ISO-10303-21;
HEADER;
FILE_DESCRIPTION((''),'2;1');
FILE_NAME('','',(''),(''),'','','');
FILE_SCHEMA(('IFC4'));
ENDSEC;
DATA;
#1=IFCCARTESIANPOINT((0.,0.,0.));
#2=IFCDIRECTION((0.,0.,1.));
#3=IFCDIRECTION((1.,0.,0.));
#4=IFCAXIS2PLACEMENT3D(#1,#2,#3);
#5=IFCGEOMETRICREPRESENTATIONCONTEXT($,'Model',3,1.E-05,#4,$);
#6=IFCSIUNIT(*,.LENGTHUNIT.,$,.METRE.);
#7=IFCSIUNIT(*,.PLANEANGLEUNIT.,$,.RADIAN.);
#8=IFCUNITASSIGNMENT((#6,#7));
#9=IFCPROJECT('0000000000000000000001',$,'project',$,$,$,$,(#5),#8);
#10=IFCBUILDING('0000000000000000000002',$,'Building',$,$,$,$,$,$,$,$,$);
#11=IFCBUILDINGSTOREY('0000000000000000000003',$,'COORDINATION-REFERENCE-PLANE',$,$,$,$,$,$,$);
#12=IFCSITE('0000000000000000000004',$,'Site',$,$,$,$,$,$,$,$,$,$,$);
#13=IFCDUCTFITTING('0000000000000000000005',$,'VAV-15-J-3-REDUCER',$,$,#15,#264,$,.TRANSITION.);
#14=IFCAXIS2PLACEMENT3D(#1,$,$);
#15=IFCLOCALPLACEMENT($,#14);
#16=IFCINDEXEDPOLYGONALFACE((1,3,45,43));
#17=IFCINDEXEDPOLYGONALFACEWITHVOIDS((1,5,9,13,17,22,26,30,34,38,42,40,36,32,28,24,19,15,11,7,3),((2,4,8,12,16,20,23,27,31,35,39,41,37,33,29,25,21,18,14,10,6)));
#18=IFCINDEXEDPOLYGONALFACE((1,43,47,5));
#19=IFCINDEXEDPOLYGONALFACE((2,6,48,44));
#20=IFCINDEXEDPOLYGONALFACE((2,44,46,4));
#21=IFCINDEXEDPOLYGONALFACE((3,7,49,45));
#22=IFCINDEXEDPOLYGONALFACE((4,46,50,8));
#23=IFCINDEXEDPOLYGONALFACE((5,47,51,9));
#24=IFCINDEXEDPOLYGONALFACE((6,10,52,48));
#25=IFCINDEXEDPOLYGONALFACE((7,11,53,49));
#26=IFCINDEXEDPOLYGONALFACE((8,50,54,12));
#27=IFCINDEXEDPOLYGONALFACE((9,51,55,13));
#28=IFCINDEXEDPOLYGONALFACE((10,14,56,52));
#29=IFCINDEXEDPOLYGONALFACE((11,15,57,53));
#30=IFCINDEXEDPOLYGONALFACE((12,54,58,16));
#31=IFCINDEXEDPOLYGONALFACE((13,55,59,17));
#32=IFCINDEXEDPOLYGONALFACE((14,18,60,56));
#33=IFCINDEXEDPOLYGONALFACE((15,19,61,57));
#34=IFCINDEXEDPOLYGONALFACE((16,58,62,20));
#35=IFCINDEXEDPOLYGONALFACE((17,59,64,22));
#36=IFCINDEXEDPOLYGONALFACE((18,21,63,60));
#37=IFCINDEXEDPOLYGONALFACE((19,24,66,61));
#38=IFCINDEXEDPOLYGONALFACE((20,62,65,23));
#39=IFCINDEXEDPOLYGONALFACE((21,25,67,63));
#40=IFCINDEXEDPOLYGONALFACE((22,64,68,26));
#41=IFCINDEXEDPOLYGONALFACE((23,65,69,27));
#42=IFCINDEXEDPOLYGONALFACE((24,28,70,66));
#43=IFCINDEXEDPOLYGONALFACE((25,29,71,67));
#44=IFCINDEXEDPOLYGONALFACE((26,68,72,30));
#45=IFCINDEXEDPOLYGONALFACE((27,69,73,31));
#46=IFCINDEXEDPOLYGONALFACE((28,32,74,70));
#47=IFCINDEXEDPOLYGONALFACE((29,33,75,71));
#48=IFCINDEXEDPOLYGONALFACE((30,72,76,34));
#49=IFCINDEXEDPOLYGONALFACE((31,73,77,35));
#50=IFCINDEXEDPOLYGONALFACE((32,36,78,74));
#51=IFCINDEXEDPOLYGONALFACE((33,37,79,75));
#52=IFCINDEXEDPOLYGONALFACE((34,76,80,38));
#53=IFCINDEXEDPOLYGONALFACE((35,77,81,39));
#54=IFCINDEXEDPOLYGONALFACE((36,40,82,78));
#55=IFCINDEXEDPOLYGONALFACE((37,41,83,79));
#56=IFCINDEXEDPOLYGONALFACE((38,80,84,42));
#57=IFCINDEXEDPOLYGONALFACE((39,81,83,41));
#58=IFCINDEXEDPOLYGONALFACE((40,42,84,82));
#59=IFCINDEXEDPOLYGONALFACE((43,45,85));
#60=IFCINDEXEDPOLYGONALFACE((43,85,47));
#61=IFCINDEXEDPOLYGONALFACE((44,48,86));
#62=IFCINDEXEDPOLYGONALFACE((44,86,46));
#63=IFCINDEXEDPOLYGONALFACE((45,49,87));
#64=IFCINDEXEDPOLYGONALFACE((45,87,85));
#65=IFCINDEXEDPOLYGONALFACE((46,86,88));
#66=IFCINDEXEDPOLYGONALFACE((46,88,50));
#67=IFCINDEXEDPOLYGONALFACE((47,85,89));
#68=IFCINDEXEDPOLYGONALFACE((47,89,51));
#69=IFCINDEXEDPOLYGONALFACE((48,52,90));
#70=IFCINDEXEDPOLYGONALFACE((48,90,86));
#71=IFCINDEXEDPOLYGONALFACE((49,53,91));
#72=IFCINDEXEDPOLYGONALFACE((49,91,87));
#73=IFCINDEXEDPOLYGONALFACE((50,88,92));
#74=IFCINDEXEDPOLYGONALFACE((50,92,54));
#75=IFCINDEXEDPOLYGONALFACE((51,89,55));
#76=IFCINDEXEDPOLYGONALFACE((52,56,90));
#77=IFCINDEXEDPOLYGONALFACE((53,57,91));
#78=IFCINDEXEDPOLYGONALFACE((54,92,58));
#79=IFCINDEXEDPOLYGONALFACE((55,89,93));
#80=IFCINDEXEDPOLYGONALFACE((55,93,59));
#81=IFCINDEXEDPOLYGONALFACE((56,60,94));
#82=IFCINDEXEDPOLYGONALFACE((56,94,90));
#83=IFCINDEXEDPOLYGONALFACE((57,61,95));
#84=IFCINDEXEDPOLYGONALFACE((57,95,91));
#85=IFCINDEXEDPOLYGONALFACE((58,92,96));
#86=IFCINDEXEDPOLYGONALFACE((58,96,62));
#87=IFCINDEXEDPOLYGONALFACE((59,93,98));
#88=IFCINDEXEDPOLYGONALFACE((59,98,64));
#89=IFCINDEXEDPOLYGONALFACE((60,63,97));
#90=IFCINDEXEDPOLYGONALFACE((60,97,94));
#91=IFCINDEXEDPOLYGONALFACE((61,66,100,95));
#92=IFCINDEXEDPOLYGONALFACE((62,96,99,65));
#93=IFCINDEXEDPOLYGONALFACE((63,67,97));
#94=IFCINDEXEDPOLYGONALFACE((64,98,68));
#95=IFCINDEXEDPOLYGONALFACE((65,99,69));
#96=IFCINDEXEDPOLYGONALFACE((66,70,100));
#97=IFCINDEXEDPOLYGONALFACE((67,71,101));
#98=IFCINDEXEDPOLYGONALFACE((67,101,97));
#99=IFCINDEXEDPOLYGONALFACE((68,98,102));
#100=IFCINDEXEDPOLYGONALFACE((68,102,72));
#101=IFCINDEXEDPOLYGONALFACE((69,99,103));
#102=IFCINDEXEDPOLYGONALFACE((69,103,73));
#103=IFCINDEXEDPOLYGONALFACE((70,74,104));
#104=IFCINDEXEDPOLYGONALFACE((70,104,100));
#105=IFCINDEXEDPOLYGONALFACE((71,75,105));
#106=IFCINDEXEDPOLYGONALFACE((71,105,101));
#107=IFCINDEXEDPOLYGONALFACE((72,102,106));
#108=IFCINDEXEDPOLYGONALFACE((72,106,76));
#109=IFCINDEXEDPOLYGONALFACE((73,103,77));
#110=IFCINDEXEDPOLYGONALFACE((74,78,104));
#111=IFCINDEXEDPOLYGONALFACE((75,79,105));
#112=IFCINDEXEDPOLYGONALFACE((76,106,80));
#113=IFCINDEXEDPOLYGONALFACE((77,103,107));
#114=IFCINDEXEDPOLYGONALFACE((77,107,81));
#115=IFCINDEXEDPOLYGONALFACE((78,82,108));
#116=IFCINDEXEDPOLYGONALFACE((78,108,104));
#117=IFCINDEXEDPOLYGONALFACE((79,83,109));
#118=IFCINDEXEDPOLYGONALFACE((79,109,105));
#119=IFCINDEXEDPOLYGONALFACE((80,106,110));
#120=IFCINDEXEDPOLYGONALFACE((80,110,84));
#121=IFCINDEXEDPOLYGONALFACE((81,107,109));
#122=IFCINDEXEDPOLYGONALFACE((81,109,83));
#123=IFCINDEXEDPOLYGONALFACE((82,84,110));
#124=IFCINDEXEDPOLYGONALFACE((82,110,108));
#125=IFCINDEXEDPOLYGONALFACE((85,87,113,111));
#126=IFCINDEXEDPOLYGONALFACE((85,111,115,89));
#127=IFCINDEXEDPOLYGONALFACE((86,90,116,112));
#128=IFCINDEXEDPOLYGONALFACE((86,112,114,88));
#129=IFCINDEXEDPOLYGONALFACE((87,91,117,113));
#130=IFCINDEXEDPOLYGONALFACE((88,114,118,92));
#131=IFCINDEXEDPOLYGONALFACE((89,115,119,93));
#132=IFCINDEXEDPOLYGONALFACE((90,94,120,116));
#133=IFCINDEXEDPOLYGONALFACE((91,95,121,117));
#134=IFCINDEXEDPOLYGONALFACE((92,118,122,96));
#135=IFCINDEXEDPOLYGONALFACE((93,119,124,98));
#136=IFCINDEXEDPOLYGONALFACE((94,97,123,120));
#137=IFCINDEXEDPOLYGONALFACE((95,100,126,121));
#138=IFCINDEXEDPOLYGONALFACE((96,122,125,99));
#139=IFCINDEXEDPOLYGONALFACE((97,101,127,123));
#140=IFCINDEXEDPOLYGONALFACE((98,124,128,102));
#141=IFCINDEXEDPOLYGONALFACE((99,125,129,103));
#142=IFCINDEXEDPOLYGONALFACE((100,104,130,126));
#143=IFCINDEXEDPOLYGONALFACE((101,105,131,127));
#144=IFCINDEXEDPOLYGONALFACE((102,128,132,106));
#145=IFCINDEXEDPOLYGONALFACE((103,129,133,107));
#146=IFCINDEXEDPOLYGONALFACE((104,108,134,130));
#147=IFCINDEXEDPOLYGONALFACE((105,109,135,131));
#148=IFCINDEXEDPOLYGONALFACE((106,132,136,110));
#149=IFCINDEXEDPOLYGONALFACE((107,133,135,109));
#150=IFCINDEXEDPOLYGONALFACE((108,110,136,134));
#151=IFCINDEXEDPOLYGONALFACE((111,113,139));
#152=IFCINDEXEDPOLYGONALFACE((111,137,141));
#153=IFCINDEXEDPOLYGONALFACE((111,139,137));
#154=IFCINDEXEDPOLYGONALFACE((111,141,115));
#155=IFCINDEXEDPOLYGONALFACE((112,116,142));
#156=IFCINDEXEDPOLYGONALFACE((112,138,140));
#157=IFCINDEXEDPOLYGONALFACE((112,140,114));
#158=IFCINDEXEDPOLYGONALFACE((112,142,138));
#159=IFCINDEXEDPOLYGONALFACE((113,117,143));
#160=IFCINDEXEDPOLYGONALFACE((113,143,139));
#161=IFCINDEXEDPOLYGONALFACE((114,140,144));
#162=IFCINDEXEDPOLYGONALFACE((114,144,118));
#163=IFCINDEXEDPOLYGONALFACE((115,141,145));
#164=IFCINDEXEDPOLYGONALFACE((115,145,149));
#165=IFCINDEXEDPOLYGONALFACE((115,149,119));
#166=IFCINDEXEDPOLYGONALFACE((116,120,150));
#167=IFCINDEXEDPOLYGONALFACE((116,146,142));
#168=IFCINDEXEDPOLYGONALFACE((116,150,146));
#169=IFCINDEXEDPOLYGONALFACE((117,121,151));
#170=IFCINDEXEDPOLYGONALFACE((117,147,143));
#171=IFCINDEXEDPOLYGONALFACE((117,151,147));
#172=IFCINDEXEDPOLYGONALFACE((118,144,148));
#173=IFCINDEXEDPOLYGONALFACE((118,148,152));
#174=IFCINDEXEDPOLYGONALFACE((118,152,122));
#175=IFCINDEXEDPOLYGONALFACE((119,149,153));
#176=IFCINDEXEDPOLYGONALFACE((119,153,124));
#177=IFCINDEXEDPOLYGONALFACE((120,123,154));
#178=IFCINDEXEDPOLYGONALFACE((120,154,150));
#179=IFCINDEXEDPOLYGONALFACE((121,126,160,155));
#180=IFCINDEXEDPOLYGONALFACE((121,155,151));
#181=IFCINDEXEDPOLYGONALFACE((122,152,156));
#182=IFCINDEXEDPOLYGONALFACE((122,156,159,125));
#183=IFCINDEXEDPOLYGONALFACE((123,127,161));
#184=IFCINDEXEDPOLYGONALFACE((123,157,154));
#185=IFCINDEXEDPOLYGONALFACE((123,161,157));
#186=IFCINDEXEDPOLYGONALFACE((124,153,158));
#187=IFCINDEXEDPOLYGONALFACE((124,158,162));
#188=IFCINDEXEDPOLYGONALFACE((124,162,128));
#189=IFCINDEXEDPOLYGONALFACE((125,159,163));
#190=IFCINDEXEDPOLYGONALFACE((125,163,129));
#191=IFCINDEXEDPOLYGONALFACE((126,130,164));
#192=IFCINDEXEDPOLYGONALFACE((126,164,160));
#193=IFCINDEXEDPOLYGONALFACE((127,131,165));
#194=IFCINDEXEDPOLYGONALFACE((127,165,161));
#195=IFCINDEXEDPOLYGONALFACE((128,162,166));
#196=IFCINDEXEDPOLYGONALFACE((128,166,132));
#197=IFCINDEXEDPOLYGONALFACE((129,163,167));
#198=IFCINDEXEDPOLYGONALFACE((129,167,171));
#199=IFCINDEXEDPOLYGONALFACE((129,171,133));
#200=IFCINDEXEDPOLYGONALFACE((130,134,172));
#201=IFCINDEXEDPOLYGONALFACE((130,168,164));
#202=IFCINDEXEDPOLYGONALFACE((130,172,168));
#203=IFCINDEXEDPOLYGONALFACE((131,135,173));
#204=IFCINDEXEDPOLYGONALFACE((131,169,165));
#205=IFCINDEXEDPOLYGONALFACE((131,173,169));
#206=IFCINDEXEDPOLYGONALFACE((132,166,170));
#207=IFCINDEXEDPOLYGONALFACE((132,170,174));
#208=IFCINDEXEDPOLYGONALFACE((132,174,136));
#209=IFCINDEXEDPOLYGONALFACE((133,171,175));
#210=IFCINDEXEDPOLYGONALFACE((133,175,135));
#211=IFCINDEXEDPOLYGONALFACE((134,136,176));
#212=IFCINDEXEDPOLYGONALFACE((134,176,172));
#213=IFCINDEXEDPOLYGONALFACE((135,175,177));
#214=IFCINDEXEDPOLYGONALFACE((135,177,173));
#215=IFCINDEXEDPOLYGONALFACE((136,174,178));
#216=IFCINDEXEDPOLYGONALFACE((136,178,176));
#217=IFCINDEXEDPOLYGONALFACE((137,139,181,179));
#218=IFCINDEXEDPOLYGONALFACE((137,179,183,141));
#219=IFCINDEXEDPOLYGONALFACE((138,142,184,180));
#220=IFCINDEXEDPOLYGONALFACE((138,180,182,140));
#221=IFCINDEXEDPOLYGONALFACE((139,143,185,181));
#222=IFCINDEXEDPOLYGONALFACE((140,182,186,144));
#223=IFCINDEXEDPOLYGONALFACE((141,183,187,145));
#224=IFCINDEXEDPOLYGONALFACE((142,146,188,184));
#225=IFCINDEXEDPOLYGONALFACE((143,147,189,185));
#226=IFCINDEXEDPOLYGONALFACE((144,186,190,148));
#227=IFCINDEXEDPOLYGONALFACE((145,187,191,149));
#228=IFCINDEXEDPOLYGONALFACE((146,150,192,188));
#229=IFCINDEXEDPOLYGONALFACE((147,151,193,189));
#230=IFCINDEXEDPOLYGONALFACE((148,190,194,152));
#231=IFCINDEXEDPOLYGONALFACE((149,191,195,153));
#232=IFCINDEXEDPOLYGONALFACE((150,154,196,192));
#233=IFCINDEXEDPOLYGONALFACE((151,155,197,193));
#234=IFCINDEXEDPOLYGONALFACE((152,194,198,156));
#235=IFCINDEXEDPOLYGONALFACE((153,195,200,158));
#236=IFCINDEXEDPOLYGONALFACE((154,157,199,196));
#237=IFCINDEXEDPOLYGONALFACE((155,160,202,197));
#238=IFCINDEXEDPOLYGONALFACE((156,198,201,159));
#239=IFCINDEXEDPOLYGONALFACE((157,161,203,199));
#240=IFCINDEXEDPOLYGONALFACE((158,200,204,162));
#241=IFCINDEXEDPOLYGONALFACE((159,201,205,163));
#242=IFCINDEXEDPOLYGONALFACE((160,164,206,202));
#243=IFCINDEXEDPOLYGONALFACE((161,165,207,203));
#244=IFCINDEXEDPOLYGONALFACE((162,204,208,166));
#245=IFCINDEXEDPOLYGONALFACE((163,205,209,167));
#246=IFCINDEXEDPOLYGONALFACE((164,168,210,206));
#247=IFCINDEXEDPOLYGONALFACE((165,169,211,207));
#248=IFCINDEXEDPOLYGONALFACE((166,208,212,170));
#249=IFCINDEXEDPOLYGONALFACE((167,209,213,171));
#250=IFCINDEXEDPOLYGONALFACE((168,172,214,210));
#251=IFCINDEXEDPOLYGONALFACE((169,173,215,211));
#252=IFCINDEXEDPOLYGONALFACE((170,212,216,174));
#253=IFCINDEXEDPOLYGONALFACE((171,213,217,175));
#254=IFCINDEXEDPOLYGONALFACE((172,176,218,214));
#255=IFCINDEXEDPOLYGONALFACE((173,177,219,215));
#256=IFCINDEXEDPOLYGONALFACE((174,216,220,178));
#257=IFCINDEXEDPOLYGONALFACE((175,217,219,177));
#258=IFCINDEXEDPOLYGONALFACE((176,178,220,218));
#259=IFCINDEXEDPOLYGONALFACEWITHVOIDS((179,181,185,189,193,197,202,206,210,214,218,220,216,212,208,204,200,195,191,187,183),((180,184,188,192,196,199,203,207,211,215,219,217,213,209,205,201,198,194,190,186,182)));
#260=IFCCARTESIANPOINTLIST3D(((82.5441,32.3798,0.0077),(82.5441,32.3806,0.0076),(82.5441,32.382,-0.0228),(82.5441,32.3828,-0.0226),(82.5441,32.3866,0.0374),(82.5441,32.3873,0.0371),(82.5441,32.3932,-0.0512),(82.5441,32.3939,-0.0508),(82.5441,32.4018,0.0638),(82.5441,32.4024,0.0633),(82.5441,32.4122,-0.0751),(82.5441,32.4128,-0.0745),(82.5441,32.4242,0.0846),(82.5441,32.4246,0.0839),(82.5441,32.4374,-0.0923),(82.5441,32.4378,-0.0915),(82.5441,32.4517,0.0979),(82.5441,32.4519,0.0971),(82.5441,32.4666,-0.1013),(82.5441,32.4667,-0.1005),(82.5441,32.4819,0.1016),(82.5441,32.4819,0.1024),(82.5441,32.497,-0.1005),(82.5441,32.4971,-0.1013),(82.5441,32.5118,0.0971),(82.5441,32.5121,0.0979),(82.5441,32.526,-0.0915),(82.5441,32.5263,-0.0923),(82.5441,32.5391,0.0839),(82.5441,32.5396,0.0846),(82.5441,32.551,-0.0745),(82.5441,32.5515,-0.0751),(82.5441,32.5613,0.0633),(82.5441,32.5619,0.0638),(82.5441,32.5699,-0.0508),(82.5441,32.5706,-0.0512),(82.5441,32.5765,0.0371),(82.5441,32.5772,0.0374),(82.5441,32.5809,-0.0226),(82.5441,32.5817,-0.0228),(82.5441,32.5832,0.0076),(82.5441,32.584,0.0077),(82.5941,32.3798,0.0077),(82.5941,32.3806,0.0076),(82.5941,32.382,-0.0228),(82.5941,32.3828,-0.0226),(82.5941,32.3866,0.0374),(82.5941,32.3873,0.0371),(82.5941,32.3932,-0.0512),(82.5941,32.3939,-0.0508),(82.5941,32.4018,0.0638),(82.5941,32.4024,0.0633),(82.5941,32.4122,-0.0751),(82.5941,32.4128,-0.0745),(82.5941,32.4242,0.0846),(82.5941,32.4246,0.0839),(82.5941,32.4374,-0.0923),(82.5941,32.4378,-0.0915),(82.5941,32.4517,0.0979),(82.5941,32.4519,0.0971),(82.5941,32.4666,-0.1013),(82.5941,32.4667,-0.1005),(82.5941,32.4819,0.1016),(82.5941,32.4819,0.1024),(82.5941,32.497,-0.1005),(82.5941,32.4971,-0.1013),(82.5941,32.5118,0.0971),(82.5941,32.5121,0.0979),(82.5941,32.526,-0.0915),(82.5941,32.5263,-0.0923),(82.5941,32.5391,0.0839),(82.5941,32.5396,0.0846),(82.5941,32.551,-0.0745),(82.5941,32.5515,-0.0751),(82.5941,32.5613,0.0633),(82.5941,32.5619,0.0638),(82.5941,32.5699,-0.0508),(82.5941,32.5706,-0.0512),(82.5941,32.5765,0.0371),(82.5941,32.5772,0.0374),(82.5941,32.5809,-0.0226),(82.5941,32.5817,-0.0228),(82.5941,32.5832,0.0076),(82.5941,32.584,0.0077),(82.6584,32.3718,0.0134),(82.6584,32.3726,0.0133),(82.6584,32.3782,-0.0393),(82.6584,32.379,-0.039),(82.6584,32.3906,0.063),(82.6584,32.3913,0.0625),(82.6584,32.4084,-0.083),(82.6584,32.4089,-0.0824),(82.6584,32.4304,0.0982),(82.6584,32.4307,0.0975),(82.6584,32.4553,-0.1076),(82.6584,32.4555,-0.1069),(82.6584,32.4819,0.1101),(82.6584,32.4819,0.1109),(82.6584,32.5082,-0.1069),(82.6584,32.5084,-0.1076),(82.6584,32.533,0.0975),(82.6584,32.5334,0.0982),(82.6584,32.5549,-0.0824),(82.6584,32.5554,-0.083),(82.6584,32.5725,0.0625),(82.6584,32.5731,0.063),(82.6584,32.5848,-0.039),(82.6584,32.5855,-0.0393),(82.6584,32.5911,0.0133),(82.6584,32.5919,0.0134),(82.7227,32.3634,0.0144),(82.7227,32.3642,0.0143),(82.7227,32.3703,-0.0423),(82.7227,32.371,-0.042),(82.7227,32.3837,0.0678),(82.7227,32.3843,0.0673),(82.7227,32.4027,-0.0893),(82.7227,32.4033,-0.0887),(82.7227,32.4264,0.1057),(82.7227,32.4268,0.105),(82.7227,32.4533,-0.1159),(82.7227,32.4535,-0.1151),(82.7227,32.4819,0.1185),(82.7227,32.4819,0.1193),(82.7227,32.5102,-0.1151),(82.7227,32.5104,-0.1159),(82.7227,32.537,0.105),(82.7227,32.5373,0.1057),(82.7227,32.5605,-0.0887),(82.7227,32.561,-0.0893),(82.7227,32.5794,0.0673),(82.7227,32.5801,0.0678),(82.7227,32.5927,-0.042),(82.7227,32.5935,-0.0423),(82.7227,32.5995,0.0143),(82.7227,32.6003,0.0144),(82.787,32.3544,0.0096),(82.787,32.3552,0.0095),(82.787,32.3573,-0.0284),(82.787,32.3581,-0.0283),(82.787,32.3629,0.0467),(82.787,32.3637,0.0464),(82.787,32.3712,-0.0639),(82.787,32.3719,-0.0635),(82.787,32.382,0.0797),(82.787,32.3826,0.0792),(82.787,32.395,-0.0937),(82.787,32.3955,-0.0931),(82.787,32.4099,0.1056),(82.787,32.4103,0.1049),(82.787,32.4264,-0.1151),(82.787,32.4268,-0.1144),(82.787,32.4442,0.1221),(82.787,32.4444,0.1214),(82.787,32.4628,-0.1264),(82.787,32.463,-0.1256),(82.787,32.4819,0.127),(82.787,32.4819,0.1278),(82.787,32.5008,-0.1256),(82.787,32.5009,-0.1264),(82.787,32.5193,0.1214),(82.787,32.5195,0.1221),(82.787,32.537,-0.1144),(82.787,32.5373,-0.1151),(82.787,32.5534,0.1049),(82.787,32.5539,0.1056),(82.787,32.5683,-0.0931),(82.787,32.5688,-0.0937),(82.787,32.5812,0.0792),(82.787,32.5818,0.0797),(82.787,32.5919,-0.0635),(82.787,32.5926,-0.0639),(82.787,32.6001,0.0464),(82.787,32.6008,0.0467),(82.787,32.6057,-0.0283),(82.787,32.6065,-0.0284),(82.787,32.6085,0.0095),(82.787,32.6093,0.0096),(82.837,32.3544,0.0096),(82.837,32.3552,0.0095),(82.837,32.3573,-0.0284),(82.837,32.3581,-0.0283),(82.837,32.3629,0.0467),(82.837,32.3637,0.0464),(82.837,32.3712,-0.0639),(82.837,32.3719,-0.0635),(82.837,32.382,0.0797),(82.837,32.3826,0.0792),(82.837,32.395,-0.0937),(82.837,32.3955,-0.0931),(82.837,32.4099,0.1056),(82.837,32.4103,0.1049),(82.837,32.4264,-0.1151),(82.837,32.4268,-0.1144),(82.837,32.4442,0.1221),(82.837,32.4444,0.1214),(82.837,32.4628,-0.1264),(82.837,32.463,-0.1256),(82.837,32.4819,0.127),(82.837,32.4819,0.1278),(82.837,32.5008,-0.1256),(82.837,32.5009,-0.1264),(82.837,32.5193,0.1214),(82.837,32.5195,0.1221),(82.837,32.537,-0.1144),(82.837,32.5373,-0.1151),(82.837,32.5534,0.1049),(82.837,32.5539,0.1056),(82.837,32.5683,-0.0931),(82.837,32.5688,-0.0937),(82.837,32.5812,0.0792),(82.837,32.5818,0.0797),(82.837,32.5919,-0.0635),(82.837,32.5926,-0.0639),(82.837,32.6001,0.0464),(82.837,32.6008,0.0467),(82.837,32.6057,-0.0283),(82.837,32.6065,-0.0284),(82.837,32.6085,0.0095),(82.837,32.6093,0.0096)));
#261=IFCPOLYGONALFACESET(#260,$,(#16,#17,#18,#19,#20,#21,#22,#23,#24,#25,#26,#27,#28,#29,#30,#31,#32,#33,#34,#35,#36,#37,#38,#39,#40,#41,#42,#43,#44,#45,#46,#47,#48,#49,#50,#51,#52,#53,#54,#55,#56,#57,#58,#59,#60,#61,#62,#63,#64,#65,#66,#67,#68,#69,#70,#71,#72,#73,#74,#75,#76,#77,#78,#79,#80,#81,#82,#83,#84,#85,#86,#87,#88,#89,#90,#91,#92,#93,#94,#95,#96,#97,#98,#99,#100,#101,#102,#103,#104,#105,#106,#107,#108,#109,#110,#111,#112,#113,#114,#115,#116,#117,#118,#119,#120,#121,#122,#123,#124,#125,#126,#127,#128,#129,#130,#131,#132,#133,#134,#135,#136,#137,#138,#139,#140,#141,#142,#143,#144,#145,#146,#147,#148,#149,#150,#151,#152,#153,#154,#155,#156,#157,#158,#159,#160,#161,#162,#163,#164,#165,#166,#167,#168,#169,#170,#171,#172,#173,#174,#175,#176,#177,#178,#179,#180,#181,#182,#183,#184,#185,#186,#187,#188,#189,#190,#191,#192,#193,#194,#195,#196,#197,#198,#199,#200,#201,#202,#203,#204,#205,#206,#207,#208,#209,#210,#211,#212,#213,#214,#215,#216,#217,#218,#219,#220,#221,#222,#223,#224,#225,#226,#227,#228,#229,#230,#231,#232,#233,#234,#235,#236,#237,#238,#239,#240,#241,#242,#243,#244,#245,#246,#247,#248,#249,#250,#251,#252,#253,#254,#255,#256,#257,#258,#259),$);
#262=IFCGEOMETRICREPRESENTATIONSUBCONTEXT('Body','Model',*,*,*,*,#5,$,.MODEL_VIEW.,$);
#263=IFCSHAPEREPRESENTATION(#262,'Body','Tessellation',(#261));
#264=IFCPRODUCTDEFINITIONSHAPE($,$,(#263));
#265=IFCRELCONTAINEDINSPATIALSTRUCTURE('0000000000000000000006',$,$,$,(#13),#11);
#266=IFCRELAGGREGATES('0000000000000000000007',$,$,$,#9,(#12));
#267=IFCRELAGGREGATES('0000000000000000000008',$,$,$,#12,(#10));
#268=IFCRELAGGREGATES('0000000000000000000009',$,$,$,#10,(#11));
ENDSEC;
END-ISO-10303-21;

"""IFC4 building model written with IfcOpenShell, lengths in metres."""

from ifc_helpers import new_model, entity, si_unit, frame, origin_with_axes, place, context, subcontext, project, spatial, element, save


model = new_model("IFC4")

# Units and contexts
model_context = context("Model", 3, precision=1e-05, world=origin_with_axes())
body_context_1 = subcontext(model_context, "Body", "Model", "MODEL_VIEW")
ifc_project = project(units=[si_unit("LENGTHUNIT", "METRE"), si_unit("PLANEANGLEUNIT", "RADIAN")], contexts=[model_context])

# Site, building, storey
site = spatial("IfcSite", under=ifc_project, Name="Site")
building = spatial("IfcBuilding", under=site, Name="Building")
storey = spatial("IfcBuildingStorey", under=building, Name="COORDINATION-REFERENCE-PLANE")

# Duct fitting
for number, where, z_axis, x_axis, name in (
    (1, (82.837, 32.4819, 0.0), (0.0, -1.0, 0.0), (0.0, 0.0, 1.0), "VAV-15-J-3-REDUCER"),
):
    element("IfcDuctFitting", number, at=place(None, frame(where, z_axis=z_axis, x_axis=x_axis)), inside=storey, Name=name, PredefinedType="TRANSITION", context=body_context_1, shape_type="SweptSolid", body=[
        entity("IfcRevolvedAreaSolid", entity("IfcArbitraryClosedProfileDef", "AREA", None, entity("IfcPolyline", [entity("IfcCartesianPoint", [0.1278, 0.0]), entity("IfcCartesianPoint", [0.1278, 0.05]), entity("IfcCartesianPoint", [0.1024, 0.2429]), entity("IfcCartesianPoint", [0.1024, 0.2929]), entity("IfcCartesianPoint", [0.1016, 0.2929]), entity("IfcCartesianPoint", [0.1016, 0.2429]), entity("IfcCartesianPoint", [0.127, 0.05]), entity("IfcCartesianPoint", [0.127, 0.0]), entity("IfcCartesianPoint", [0.1278, 0.0])])), entity("IfcAxis2Placement3D", entity("IfcCartesianPoint", [0.0, 0.0, 0.0])), entity("IfcAxis1Placement", entity("IfcCartesianPoint", [0.0, 0.0, 0.0]), entity("IfcDirection", [0.0, 1.0, 0.0])), 6.283185),
    ])

save(model, "model.ifc")
